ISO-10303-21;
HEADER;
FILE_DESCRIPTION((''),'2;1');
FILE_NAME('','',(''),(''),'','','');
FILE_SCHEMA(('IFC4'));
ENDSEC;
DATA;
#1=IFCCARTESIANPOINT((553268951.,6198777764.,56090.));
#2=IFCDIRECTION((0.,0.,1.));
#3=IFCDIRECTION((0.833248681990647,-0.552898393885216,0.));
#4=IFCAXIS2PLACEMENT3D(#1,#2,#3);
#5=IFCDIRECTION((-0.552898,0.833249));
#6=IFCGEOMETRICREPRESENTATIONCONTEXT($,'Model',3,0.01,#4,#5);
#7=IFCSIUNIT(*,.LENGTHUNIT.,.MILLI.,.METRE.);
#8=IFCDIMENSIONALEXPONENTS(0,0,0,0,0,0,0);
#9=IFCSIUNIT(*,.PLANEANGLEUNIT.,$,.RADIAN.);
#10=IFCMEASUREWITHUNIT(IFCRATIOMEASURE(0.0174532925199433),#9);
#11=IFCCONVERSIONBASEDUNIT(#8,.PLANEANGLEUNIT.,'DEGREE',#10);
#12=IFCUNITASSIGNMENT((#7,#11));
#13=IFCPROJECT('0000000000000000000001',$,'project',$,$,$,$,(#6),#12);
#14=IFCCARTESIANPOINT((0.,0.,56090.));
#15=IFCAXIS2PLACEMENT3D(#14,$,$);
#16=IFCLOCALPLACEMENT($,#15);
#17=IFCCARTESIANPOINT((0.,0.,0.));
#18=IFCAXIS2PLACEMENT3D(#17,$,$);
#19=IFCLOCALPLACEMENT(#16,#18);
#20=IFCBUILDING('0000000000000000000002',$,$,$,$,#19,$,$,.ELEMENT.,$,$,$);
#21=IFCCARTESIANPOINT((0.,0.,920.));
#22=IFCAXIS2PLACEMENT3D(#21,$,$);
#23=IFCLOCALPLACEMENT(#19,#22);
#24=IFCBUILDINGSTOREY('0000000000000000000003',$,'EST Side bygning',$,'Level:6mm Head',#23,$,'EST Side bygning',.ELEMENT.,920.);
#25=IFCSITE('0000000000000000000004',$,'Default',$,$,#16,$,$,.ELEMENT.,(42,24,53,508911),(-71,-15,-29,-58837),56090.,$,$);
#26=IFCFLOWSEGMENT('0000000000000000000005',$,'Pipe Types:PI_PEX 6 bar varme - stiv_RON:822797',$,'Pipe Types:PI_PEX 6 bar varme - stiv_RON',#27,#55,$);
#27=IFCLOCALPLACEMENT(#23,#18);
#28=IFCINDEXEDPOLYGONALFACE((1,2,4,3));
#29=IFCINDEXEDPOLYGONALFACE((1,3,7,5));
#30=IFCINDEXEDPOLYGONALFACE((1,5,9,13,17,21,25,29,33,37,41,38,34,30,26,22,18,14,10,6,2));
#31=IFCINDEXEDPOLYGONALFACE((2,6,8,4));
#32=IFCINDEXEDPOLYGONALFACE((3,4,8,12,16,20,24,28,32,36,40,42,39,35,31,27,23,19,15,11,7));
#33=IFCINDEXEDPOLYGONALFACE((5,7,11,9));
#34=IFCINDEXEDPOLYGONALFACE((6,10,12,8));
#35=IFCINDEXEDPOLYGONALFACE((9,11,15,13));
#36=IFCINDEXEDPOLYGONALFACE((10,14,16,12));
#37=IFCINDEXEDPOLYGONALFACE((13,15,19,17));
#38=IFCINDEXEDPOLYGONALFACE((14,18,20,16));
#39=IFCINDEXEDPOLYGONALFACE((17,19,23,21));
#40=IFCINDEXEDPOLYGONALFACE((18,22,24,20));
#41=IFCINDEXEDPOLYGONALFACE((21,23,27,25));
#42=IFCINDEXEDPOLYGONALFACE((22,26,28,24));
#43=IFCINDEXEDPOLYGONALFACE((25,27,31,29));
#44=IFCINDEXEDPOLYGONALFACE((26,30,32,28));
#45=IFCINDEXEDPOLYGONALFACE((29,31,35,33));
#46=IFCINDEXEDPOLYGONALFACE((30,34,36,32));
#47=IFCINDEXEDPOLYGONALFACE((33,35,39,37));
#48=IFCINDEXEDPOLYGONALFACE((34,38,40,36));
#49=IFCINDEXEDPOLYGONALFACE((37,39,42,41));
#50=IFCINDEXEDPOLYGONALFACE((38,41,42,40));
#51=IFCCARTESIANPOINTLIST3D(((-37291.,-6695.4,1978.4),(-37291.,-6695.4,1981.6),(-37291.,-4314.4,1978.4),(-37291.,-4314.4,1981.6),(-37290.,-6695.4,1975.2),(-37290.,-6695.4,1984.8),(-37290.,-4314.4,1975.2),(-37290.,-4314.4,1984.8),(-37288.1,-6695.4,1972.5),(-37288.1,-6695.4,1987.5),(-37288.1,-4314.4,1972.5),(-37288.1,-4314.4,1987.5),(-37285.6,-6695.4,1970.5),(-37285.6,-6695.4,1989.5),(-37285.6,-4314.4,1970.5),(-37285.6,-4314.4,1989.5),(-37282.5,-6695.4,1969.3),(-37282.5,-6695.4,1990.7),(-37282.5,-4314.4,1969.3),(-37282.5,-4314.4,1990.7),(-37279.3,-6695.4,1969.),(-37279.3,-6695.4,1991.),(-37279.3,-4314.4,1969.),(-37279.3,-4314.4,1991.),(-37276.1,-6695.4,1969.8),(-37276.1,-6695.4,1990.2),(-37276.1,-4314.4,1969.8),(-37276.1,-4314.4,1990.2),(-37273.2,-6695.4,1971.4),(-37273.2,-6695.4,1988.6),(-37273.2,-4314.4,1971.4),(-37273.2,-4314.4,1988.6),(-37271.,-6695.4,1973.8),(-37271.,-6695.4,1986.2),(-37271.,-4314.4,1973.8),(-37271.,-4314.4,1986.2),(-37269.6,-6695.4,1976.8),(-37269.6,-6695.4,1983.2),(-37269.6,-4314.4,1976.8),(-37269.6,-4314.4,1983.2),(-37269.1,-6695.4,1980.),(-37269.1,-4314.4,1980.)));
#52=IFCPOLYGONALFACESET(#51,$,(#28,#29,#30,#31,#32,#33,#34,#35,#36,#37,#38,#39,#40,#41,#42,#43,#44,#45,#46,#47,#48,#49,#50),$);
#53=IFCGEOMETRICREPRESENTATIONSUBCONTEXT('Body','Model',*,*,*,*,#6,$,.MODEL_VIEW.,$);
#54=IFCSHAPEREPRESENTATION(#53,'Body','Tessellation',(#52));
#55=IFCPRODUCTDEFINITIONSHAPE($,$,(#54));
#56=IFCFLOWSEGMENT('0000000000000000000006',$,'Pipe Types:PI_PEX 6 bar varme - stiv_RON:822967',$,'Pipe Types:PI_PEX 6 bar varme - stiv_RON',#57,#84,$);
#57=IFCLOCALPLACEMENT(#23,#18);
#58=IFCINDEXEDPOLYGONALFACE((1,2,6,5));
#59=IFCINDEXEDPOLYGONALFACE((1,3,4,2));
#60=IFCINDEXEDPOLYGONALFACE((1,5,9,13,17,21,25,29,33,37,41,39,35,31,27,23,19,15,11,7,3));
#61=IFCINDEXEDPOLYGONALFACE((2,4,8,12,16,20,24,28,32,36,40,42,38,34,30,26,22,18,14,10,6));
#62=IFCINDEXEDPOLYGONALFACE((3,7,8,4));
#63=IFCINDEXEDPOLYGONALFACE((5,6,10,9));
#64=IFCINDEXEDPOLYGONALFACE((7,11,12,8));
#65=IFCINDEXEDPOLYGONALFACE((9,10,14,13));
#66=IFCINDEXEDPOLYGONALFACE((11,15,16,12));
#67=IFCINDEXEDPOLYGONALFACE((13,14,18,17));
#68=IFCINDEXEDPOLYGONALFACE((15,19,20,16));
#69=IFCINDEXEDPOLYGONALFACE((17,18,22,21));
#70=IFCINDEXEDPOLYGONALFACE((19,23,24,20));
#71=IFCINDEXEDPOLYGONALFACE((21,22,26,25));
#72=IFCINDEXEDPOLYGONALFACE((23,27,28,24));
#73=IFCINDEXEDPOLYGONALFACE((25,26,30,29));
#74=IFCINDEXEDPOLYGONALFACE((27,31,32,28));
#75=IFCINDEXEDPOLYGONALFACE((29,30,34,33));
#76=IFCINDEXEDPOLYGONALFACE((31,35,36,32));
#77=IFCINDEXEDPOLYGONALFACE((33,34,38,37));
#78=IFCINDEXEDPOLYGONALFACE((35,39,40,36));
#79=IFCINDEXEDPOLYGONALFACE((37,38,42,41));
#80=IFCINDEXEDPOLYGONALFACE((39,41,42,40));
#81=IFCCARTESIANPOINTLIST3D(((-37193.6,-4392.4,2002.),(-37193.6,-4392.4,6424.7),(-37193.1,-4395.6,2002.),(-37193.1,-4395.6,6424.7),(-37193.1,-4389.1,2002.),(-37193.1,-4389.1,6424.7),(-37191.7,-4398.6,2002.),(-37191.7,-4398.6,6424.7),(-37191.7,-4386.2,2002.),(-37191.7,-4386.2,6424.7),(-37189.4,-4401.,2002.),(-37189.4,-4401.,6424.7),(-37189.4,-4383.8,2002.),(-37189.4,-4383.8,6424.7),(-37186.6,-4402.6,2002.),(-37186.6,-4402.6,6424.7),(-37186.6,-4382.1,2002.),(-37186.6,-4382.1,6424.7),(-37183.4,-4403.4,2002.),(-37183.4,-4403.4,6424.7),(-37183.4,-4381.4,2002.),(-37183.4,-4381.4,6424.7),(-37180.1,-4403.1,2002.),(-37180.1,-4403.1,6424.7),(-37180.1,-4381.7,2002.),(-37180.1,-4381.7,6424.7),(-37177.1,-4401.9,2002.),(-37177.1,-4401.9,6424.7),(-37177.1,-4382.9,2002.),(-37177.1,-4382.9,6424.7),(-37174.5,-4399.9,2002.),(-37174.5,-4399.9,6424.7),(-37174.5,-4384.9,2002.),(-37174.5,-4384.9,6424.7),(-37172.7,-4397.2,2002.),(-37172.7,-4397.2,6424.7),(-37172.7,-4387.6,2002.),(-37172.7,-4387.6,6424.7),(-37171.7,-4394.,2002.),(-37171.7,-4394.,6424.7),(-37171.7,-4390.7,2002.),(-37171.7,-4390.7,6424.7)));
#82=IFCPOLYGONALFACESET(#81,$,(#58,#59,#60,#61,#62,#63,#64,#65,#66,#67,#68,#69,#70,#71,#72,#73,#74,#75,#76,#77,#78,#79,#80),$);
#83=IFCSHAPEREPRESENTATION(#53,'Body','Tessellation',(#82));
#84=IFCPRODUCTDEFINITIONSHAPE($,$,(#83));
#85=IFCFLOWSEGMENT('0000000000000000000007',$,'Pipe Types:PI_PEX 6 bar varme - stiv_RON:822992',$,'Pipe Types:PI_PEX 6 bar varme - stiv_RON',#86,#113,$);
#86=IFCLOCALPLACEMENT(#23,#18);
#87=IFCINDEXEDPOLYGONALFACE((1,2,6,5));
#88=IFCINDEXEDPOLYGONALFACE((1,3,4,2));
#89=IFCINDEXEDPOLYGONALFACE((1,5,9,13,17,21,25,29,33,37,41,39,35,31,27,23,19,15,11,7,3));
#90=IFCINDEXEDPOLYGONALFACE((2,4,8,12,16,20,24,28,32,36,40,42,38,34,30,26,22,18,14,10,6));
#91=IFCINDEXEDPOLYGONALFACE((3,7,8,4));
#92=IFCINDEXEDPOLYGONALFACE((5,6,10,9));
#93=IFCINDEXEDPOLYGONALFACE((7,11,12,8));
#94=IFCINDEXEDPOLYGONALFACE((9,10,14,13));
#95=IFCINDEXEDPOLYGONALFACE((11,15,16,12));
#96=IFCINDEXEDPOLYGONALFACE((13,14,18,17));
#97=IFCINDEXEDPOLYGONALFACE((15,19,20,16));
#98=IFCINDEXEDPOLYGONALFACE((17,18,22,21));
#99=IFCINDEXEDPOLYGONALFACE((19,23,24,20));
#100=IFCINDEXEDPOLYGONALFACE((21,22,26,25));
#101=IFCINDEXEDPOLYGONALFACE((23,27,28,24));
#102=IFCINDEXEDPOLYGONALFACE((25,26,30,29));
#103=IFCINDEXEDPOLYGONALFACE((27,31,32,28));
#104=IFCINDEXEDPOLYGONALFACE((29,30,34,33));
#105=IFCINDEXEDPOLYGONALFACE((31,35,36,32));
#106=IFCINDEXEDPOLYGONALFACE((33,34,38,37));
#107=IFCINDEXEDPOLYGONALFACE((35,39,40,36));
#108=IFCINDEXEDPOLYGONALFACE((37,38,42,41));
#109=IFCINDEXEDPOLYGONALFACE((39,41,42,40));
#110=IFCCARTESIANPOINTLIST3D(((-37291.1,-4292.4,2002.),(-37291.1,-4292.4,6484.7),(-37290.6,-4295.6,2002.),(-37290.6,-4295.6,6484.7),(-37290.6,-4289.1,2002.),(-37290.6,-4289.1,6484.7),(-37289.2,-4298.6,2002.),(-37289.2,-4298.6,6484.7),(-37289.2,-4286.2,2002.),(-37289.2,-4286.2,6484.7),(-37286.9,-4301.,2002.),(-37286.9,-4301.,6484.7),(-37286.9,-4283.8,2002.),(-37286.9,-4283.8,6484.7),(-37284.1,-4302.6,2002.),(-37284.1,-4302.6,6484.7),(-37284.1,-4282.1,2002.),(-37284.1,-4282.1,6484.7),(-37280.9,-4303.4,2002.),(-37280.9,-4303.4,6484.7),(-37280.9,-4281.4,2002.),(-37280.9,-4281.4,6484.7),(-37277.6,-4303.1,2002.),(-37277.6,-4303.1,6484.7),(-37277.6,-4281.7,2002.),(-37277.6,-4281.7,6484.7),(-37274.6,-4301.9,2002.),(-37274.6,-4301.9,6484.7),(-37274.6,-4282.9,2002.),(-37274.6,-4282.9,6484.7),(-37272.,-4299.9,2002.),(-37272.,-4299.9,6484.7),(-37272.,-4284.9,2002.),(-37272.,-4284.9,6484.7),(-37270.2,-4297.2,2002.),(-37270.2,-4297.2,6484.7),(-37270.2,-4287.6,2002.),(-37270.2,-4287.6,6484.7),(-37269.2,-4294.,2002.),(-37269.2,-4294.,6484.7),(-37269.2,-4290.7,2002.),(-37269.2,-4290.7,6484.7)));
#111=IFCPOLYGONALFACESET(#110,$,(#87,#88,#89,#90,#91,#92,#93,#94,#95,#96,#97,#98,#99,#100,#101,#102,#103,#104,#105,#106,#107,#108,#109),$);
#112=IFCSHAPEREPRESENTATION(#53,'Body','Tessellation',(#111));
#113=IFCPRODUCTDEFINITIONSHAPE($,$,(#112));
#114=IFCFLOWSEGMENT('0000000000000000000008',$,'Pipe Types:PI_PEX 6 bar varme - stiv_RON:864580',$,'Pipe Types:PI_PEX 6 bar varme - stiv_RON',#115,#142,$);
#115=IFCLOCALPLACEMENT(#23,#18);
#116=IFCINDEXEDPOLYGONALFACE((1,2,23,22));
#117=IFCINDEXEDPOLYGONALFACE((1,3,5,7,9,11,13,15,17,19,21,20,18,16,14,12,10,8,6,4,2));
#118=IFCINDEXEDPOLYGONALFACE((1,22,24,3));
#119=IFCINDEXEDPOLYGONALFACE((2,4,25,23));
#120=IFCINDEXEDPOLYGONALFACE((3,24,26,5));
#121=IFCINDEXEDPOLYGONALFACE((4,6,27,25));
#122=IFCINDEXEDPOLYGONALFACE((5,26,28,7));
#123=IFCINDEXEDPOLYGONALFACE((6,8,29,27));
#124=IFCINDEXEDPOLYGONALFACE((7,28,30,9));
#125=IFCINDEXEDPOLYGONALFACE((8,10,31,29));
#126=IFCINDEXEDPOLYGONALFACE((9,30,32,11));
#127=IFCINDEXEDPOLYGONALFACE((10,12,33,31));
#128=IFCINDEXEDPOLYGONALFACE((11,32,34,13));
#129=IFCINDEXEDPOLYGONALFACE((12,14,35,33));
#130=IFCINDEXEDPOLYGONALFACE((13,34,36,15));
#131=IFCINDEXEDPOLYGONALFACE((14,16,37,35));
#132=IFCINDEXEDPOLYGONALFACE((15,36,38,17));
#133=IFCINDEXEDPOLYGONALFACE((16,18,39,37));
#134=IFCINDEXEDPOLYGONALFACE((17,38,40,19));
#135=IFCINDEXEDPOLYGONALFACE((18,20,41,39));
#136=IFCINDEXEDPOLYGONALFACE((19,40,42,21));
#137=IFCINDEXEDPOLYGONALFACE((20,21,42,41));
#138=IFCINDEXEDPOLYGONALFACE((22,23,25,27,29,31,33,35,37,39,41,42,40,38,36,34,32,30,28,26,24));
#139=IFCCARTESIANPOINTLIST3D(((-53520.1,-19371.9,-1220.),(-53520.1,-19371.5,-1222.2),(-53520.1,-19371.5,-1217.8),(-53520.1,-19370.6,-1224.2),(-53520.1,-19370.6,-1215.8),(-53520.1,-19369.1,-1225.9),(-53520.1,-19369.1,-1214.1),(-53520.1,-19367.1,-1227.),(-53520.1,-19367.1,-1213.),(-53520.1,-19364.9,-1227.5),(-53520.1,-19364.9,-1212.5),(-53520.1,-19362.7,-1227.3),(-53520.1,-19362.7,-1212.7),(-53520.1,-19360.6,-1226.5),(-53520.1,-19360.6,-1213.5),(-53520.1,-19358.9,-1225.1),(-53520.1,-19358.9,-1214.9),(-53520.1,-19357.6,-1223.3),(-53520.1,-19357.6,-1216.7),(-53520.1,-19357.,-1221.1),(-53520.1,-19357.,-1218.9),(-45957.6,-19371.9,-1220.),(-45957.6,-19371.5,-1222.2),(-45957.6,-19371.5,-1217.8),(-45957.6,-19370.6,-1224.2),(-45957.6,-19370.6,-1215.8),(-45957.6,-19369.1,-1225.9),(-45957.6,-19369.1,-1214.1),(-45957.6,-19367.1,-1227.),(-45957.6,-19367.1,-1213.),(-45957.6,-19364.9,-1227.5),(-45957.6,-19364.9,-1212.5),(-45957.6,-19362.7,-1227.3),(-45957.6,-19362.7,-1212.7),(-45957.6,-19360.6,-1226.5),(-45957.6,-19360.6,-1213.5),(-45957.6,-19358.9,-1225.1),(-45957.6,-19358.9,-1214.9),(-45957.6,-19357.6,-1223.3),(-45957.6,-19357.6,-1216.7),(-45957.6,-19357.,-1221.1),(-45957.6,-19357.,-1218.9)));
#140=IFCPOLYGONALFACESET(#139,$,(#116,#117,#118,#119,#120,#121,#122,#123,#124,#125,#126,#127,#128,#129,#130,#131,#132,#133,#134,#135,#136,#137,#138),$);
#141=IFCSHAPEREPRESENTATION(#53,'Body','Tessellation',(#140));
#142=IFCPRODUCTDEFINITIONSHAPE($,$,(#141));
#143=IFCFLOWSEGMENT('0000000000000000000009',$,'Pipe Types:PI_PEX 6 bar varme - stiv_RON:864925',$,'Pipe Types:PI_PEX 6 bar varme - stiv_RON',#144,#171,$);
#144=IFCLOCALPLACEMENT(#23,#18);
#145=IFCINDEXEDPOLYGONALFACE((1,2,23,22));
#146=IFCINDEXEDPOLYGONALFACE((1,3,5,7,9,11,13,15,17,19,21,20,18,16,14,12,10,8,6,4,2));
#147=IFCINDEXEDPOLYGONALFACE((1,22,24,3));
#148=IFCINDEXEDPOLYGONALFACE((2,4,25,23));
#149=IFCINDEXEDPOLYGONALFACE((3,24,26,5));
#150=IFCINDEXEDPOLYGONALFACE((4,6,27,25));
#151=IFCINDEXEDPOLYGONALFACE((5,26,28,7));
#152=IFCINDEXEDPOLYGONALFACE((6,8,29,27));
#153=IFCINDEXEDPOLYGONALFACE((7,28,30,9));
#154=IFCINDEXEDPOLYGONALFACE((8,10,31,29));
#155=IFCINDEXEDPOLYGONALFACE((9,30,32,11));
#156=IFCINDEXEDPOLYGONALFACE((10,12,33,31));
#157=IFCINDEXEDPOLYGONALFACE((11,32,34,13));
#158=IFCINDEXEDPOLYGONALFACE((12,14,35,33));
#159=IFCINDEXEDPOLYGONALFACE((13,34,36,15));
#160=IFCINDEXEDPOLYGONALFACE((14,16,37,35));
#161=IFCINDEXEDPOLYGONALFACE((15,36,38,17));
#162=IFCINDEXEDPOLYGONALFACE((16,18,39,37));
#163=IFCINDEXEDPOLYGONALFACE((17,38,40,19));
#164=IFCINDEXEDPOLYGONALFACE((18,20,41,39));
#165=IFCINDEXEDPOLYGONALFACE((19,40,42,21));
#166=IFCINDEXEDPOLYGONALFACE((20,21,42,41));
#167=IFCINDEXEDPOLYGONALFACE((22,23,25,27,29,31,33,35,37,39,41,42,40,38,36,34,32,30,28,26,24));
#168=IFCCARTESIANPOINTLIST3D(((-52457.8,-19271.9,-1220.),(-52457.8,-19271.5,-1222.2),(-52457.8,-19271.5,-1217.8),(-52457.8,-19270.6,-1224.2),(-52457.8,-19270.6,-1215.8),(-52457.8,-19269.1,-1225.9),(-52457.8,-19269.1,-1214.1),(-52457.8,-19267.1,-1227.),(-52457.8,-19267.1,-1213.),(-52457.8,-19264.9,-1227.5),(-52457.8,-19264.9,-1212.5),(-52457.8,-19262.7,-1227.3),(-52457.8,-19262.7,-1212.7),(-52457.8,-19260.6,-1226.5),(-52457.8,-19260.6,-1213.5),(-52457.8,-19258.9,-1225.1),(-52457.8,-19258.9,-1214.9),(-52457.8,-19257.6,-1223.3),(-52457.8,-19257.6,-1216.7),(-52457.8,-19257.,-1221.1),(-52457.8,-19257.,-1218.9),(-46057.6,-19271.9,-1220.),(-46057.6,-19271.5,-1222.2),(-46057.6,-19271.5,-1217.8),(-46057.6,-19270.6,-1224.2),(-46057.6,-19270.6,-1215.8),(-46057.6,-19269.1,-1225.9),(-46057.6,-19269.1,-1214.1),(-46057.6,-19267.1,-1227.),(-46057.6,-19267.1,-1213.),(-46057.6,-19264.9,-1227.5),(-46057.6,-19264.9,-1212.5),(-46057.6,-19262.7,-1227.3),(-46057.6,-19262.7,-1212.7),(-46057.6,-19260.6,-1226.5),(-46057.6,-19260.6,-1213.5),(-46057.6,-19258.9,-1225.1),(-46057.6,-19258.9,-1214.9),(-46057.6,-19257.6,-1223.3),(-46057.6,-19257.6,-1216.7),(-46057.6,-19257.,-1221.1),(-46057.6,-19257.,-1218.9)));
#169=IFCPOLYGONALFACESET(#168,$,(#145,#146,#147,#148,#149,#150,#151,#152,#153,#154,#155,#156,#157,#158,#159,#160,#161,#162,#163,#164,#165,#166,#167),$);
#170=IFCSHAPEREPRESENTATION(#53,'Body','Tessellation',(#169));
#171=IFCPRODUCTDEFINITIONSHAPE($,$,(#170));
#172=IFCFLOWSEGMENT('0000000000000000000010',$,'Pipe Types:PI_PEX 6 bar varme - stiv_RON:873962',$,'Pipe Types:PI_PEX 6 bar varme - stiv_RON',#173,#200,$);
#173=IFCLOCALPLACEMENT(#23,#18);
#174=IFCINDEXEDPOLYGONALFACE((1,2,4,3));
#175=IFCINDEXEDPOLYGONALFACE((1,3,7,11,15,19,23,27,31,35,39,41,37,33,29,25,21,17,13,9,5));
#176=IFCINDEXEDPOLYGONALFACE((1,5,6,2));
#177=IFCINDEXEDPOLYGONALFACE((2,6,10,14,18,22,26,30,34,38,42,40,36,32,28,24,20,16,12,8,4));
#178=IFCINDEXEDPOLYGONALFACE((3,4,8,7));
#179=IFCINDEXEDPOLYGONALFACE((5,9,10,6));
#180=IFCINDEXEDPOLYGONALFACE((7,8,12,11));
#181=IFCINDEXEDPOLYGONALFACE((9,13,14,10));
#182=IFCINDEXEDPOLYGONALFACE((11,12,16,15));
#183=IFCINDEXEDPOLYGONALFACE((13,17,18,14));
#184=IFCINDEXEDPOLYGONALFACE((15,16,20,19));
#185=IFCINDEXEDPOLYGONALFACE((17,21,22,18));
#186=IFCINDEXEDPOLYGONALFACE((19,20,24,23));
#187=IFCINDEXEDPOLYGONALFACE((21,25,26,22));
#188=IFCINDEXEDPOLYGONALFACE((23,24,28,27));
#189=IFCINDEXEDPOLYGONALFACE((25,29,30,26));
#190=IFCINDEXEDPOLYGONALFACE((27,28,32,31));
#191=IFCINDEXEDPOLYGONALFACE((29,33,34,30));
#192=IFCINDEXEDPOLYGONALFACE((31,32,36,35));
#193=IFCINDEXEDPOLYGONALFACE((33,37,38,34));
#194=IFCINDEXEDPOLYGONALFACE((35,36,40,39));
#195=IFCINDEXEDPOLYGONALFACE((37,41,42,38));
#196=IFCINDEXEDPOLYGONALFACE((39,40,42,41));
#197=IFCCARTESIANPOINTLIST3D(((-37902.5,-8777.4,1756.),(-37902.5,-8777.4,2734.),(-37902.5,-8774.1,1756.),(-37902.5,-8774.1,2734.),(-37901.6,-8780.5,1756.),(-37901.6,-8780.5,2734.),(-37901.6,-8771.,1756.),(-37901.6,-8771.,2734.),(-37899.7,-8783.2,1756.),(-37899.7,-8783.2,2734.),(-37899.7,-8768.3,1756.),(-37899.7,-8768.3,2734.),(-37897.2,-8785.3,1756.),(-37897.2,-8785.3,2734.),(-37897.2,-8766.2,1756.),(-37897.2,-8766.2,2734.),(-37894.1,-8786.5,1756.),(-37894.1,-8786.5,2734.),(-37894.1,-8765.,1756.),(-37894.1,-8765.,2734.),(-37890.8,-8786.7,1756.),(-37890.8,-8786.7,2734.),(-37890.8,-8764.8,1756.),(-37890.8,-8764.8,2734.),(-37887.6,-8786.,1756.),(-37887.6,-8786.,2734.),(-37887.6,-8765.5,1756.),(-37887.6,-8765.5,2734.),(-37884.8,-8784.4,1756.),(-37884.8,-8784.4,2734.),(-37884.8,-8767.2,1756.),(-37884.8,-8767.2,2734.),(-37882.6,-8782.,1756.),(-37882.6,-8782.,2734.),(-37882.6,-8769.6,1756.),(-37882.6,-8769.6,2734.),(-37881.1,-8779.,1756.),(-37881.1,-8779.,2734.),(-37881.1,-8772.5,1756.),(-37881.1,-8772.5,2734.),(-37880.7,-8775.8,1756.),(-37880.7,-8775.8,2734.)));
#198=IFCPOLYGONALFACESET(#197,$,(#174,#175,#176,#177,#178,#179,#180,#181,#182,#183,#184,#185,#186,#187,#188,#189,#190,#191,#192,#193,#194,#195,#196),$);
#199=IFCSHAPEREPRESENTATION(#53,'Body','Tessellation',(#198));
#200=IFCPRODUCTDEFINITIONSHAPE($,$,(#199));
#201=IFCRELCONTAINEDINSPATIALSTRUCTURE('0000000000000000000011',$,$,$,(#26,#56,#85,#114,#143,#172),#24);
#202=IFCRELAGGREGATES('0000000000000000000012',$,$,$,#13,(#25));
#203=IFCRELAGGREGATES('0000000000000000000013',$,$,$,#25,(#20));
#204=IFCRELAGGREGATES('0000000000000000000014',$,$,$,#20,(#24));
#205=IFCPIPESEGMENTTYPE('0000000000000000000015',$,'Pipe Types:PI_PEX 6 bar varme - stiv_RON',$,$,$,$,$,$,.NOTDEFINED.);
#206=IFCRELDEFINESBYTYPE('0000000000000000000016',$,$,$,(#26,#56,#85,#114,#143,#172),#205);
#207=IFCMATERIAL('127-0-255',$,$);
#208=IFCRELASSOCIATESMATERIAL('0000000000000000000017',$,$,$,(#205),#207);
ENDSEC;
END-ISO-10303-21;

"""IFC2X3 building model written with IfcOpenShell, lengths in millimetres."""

from ifc_helpers import new_model, entity, si_unit, converted_unit, direction, frame, frame_2d, origin, origin_2d_with_axis, place, context, subcontext, project, spatial, circle, extrude, material, type_object, element, save


model = new_model("IFC2X3")

# Units and contexts
model_context = context("Model", 3, precision=0.01, world=frame((553268951.0, 6198777764.0, 56090.0), z_axis=(0.0, 0.0, 1.0), x_axis=(0.833248681990647, -0.552898393885216, 0.0)), true_north=direction((-0.552898, 0.833249)))
body_context = subcontext(model_context, "Body", "Model", "MODEL_VIEW")
ifc_project = project(units=[si_unit("LENGTHUNIT", "METRE", prefix="MILLI"), converted_unit("PLANEANGLEUNIT", "DEGREE", entity("IfcRatioMeasure", 0.0174532925199433), si_unit("PLANEANGLEUNIT", "RADIAN"), dimensions=[0, 0, 0, 0, 0, 0, 0])], contexts=[model_context])

# Site, building, storey
site_placement = place(None, frame((0.0, 0.0, 56090.0)))
site = spatial("IfcSite", under=ifc_project, at=site_placement, Name="Default", CompositionType="ELEMENT", RefLatitude=(42, 24, 53, 508911), RefLongitude=(-71, -15, -29, -58837), RefElevation=56090.0)
building_placement = place(site_placement, origin())
building = spatial("IfcBuilding", under=site, at=building_placement, CompositionType="ELEMENT")
storey_placement = place(building_placement, frame((0.0, 0.0, 920.0)))
storey = spatial("IfcBuildingStorey", under=building, at=storey_placement, Name="EST Side bygning", ObjectType="Level:6mm Head", LongName="EST Side bygning", CompositionType="ELEMENT", Elevation=920.0)

# Flow segments
ifc_material_1 = material(Name="127-0-255")
pipe_segment_type_1 = type_object("IfcPipeSegmentType", Name="Pipe Types:PI_PEX 6 bar varme - stiv_RON", PredefinedType="NOTDEFINED", material=ifc_material_1)
flow_segment_1_placement = place(storey_placement, origin())
element("IfcFlowSegment", 1, at=flow_segment_1_placement, inside=storey, type_object=pipe_segment_type_1, Name="Pipe Types:PI_PEX 6 bar varme - stiv_RON:822797", ObjectType="Pipe Types:PI_PEX 6 bar varme - stiv_RON", context=body_context, shape_type="SweptSolid", body=[
    extrude(circle(Radius=11.0, at=frame_2d((0.0, 0.0), x_axis=(1.0, 0.0))), frame((-37280.1, -6695.4, 1980.0), z_axis=(0.0, 1.0, 0.0), x_axis=(1.0, 0.0, 0.0)), (0.0, 0.0, 1.0), 2381.0),
])
flow_segment_2_placement = place(storey_placement, origin())
element("IfcFlowSegment", 2, at=flow_segment_2_placement, inside=storey, type_object=pipe_segment_type_1, Name="Pipe Types:PI_PEX 6 bar varme - stiv_RON:822967", ObjectType="Pipe Types:PI_PEX 6 bar varme - stiv_RON", context=body_context, shape_type="SweptSolid", body=[
    extrude(circle(Radius=11.0, at=origin_2d_with_axis()), frame((-37182.6, -4392.4, 2002.0), z_axis=(0.0, 0.0, 1.0), x_axis=(-1.0, 0.0, 0.0)), (0.0, 0.0, 1.0), 4422.7),
])
flow_segment_3_placement = place(storey_placement, origin())
element("IfcFlowSegment", 3, at=flow_segment_3_placement, inside=storey, type_object=pipe_segment_type_1, Name="Pipe Types:PI_PEX 6 bar varme - stiv_RON:822992", ObjectType="Pipe Types:PI_PEX 6 bar varme - stiv_RON", context=body_context, shape_type="SweptSolid", body=[
    extrude(circle(Radius=11.0, at=origin_2d_with_axis()), frame((-37280.1, -4292.4, 2002.0), z_axis=(0.0, 0.0, 1.0), x_axis=(-1.0, 0.0, 0.0)), (0.0, 0.0, 1.0), 4482.7),
])
flow_segment_4_placement = place(storey_placement, origin())
element("IfcFlowSegment", 4, at=flow_segment_4_placement, inside=storey, type_object=pipe_segment_type_1, Name="Pipe Types:PI_PEX 6 bar varme - stiv_RON:864580", ObjectType="Pipe Types:PI_PEX 6 bar varme - stiv_RON", context=body_context, shape_type="SweptSolid", body=[
    extrude(circle(Radius=7.5, at=origin_2d_with_axis()), frame((-53520.1, -19364.4, -1220.0), z_axis=(1.0, 0.0, 0.0), x_axis=(0.0, -1.0, 0.0)), (0.0, 0.0, 1.0), 7562.5),
])
flow_segment_5_placement = place(storey_placement, origin())
element("IfcFlowSegment", 5, at=flow_segment_5_placement, inside=storey, type_object=pipe_segment_type_1, Name="Pipe Types:PI_PEX 6 bar varme - stiv_RON:864925", ObjectType="Pipe Types:PI_PEX 6 bar varme - stiv_RON", context=body_context, shape_type="SweptSolid", body=[
    extrude(circle(Radius=7.5, at=origin_2d_with_axis()), frame((-52457.8, -19264.4, -1220.0), z_axis=(1.0, 0.0, 0.0), x_axis=(0.0, -1.0, 0.0)), (0.0, 0.0, 1.0), 6400.2),
])
flow_segment_6_placement = place(storey_placement, origin())
element("IfcFlowSegment", 6, at=flow_segment_6_placement, inside=storey, type_object=pipe_segment_type_1, Name="Pipe Types:PI_PEX 6 bar varme - stiv_RON:873962", ObjectType="Pipe Types:PI_PEX 6 bar varme - stiv_RON", context=body_context, shape_type="SweptSolid", body=[
    extrude(circle(Radius=11.0, at=origin_2d_with_axis()), frame((-37891.7, -8775.8, 1756.0)), (0.0, 0.0, 1.0), 978.0),
])

save(model, "model.ifc")
